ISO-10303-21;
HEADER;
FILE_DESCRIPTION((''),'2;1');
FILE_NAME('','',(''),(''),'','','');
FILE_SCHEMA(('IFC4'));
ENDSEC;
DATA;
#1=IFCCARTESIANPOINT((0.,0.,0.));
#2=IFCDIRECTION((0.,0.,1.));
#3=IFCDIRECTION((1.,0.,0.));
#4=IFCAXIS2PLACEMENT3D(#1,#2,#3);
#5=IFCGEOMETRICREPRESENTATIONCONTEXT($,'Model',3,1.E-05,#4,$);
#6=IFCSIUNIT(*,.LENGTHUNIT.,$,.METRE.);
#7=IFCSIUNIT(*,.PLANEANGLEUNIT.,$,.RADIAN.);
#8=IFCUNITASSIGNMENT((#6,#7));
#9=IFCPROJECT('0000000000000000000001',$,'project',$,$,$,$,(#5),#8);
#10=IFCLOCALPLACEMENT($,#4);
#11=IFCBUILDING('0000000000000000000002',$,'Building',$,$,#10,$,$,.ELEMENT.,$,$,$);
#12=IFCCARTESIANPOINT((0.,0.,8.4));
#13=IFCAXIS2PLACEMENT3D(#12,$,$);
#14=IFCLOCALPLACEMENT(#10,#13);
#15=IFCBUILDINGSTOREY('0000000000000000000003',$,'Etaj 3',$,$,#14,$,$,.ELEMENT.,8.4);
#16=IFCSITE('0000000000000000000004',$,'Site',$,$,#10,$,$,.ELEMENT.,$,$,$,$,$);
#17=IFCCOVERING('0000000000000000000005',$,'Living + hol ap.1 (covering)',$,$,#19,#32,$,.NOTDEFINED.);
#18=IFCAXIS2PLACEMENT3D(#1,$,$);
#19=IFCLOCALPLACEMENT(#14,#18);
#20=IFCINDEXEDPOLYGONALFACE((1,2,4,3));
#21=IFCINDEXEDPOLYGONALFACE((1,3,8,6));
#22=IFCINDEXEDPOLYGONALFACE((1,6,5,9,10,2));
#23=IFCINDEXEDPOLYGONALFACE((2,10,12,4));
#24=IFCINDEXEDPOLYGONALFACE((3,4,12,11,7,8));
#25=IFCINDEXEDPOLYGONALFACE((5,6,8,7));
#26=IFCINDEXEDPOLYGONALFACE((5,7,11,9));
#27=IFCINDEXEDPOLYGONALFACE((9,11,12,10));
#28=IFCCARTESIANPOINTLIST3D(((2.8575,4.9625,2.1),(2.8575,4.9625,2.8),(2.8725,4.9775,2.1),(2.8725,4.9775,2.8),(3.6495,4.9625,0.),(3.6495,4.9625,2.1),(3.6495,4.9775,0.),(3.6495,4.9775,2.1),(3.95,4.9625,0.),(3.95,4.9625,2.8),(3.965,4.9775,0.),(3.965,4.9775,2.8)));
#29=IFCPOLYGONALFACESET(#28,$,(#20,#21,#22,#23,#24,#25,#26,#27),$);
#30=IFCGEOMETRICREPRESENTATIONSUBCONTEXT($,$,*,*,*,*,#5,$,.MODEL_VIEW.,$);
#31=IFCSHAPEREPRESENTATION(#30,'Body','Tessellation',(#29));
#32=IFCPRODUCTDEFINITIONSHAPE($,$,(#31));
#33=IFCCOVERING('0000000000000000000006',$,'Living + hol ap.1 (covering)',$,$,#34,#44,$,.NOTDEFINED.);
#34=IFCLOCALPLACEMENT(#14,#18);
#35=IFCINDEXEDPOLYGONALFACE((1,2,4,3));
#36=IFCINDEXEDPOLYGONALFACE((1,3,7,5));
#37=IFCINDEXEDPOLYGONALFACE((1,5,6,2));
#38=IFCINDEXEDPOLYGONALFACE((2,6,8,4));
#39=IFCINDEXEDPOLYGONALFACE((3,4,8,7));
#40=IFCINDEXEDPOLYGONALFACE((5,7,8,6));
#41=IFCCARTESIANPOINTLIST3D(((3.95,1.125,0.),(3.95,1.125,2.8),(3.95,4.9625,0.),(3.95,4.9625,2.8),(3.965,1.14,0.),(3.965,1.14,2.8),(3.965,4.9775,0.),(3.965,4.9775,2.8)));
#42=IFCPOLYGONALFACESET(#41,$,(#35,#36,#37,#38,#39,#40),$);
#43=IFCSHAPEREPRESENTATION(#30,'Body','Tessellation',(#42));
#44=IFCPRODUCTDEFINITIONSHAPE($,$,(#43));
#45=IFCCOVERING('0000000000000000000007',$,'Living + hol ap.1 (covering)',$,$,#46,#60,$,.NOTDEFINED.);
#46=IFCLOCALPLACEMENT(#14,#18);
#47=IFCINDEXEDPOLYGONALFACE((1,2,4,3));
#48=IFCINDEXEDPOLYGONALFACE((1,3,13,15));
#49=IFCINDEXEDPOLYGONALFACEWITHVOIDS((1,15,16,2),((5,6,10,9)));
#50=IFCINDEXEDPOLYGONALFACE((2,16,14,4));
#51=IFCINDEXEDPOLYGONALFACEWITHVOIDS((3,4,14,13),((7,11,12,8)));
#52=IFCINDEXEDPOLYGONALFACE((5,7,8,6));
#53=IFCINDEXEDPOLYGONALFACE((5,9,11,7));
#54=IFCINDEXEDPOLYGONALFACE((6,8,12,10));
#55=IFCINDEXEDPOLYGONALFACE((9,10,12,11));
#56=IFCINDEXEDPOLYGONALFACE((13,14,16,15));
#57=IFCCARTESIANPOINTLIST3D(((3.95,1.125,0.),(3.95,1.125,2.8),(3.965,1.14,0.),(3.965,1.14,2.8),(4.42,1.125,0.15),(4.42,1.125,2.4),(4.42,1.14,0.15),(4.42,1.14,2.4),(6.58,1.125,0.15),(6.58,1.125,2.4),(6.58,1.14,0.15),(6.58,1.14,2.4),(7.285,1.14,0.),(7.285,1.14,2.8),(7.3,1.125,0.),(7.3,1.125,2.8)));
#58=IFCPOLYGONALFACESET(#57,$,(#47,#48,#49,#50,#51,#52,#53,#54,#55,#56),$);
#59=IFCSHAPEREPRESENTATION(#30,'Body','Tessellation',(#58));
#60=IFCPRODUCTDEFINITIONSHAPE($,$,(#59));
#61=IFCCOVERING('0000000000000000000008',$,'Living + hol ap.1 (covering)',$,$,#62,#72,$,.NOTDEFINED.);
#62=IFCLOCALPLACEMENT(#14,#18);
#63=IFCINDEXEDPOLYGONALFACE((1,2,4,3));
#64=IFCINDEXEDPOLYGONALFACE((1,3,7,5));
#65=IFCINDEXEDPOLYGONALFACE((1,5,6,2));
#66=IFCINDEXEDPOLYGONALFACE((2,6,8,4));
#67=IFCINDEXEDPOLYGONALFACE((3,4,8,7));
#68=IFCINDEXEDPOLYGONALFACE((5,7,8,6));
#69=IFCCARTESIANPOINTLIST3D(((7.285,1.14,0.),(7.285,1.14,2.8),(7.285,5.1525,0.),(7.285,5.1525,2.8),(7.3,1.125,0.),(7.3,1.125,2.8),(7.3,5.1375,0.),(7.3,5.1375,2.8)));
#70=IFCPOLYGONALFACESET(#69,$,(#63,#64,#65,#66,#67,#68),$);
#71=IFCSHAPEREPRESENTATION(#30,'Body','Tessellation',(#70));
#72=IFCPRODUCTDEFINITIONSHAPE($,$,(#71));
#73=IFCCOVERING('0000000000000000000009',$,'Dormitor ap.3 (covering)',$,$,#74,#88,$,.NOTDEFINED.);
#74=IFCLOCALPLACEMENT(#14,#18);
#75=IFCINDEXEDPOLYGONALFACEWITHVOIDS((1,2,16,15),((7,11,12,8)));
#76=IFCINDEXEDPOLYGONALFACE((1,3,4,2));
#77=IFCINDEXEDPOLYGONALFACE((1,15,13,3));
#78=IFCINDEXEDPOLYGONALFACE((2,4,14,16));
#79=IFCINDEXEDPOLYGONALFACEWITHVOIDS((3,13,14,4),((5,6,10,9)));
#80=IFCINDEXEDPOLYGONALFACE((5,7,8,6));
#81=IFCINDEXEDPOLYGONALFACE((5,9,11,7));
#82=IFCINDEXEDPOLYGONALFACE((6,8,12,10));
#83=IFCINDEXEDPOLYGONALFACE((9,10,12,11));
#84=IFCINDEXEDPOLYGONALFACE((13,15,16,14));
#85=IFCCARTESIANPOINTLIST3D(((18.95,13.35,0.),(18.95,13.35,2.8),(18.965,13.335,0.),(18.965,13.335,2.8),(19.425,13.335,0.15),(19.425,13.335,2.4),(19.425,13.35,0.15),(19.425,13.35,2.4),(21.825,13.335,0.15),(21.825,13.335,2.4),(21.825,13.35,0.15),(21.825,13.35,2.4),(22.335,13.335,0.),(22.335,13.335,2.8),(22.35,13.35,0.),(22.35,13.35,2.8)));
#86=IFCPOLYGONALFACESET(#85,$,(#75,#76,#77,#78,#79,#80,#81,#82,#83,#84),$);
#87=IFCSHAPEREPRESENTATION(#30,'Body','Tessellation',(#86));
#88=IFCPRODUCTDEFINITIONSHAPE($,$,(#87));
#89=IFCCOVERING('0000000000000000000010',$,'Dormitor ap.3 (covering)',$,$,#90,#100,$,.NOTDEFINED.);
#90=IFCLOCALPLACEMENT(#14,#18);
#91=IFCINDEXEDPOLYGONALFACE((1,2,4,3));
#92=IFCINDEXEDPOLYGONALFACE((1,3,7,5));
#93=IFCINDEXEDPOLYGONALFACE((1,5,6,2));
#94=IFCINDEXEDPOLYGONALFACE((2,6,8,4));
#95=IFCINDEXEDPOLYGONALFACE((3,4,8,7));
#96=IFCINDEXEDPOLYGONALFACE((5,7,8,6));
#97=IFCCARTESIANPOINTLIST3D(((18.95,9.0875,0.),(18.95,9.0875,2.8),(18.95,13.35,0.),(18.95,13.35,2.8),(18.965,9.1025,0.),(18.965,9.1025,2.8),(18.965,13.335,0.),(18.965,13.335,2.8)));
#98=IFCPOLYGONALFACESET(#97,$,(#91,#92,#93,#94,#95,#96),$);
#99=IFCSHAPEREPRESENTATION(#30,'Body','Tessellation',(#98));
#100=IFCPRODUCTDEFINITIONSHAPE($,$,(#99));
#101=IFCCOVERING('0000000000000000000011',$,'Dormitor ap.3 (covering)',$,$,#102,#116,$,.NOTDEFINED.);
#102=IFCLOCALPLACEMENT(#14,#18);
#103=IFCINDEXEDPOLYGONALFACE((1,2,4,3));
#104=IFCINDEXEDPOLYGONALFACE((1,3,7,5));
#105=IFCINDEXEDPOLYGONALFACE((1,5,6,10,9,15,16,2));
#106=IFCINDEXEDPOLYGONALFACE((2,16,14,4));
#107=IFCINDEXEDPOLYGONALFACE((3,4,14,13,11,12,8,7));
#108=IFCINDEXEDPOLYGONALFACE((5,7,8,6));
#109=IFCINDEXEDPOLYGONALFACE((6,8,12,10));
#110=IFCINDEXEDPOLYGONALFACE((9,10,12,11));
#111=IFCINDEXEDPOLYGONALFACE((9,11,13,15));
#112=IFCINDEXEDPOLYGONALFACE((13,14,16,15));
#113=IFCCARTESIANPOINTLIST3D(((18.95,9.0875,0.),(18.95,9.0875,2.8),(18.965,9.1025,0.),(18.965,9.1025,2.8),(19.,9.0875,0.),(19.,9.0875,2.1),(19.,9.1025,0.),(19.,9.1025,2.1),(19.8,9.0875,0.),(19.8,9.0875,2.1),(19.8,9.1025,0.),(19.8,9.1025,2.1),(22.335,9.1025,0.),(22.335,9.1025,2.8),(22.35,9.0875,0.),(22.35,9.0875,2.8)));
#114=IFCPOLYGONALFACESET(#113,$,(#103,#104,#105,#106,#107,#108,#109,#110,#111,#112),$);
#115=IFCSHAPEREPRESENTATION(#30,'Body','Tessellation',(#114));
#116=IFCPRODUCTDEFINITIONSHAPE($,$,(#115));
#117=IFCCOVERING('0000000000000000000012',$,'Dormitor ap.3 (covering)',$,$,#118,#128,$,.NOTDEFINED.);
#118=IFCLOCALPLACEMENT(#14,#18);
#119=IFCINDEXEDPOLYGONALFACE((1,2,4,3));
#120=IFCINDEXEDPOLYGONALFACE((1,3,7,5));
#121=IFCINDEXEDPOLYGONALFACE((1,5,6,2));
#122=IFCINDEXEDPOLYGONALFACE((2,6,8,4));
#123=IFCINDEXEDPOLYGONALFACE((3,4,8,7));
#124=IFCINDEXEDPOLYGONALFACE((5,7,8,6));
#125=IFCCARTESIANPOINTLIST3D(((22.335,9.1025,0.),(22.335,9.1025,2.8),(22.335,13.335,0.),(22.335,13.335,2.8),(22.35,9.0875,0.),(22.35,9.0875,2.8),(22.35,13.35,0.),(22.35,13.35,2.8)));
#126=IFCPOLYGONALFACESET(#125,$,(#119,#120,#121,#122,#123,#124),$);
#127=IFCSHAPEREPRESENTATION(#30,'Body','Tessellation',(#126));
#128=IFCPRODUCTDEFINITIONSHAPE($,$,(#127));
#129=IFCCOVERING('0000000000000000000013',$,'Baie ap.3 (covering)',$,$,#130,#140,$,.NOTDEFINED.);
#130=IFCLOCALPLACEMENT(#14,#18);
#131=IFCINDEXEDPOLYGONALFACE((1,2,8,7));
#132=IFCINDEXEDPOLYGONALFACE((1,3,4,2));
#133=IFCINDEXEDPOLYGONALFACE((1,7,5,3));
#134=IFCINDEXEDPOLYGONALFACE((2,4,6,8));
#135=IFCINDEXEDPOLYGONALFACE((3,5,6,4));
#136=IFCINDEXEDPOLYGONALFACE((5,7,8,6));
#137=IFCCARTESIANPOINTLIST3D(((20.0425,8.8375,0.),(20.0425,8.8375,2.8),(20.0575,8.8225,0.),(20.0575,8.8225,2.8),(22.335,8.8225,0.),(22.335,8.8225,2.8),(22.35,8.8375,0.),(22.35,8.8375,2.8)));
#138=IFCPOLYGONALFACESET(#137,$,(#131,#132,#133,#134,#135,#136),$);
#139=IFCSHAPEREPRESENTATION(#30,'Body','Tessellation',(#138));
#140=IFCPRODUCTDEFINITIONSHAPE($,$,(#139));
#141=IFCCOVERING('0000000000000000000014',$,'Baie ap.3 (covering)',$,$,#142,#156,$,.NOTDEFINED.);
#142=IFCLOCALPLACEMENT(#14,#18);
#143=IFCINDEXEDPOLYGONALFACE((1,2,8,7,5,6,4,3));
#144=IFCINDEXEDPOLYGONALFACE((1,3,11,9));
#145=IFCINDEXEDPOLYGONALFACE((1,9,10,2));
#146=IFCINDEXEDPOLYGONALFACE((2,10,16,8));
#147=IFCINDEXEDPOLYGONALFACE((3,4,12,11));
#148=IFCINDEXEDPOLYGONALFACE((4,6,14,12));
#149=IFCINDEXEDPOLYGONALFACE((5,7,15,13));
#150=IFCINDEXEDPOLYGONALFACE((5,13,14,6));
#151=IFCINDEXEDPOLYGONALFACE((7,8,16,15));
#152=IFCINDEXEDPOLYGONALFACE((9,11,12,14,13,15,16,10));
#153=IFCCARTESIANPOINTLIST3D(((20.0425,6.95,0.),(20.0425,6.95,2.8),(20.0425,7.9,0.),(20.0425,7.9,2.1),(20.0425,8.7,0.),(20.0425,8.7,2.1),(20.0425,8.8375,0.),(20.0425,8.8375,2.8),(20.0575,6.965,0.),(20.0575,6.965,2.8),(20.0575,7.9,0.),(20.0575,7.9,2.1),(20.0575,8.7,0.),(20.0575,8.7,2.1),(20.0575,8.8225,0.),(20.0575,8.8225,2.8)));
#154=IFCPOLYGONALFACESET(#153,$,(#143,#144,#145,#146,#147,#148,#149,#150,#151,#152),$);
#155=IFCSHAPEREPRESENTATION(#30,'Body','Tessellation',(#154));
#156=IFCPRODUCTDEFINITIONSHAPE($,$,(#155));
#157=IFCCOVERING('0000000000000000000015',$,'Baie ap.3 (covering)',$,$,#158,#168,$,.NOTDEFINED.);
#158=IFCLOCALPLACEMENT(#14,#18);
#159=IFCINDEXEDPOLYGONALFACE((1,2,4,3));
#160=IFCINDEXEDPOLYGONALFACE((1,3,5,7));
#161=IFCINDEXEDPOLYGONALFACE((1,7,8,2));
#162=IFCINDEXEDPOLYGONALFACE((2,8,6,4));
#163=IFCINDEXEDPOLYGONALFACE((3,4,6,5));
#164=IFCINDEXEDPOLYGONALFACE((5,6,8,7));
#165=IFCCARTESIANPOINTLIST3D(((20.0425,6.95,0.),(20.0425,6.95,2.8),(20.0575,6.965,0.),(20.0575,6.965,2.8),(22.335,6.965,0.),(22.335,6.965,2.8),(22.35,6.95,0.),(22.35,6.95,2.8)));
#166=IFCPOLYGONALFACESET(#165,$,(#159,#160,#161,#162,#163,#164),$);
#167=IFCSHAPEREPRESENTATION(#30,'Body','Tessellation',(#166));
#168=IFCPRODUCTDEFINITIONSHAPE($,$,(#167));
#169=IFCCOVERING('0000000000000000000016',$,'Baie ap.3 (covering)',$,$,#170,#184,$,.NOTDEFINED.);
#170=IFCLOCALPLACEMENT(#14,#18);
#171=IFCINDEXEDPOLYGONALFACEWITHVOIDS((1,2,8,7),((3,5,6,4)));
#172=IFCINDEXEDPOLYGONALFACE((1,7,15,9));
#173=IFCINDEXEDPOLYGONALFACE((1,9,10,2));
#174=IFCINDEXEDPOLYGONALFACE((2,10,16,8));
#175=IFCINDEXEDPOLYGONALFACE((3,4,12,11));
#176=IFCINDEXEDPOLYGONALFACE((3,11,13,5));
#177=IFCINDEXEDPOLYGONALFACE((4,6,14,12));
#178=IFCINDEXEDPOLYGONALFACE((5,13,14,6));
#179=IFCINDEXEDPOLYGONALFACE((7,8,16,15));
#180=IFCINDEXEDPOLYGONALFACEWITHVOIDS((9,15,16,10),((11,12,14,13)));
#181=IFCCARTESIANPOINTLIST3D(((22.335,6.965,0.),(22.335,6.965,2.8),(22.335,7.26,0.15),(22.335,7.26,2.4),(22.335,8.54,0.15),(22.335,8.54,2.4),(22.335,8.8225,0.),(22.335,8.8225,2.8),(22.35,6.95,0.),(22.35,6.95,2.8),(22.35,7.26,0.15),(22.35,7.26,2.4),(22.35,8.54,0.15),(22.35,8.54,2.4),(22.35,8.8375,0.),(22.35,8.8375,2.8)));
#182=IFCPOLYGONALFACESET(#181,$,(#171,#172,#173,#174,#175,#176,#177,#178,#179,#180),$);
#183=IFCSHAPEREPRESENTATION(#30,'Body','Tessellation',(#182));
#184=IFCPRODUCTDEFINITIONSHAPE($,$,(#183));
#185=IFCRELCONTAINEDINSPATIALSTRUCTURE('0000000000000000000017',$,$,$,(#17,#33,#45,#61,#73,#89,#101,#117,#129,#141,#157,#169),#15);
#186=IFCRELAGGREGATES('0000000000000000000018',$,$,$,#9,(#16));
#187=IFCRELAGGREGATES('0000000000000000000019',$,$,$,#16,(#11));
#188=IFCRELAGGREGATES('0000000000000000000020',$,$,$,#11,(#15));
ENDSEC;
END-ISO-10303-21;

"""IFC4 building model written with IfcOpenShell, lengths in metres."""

from ifc_helpers import new_model, si_unit, frame, origin, origin_with_axes, origin_2d, place, context, subcontext, project, spatial, polyline, rectangle, outline, extrude, element, save


model = new_model("IFC4")

# Units and contexts
model_context = context("Model", 3, precision=1e-05, world=origin_with_axes())
sub_context = subcontext(model_context, None, None, "MODEL_VIEW")
ifc_project = project(units=[si_unit("LENGTHUNIT", "METRE"), si_unit("PLANEANGLEUNIT", "RADIAN")], contexts=[model_context])

# Site, building, storey
placement = place(None, origin_with_axes())
site = spatial("IfcSite", under=ifc_project, at=placement, Name="Site", CompositionType="ELEMENT")
building = spatial("IfcBuilding", under=site, at=placement, Name="Building", CompositionType="ELEMENT")
storey_placement = place(placement, frame((0.0, 0.0, 8.4)))
storey = spatial("IfcBuildingStorey", under=building, at=storey_placement, Name="Etaj 3", CompositionType="ELEMENT", Elevation=8.4)

# Covering, opening
covering_1_placement = place(storey_placement, origin_with_axes())
covering_1 = element("IfcCovering", 1, at=covering_1_placement, inside=storey, Name="Living + hol ap.1 (covering)", PredefinedType="NOTDEFINED", context=sub_context, shape_type="SweptSolid", body=[
    extrude(outline(polyline([(2.8575, 4.9625), (3.95, 4.9625), (3.965, 4.9775), (2.8725, 4.9775), (2.8575, 4.9625)])), origin(), (0.0, 0.0, 1.0), 2.8),
])
opening_1_placement = place(covering_1_placement, frame((3.2495, 5.0275, 0.0), z_axis=(0.0, -1.0, 0.0), x_axis=(1.0, 0.0, 0.0)))
element("IfcOpeningElement", 2, at=opening_1_placement, cuts=covering_1, PredefinedType="OPENING", context=sub_context, shape_type="SweptSolid", body=[
    extrude(rectangle(XDim=0.8, YDim=2.1, at=origin_2d()), frame((0.0, 1.05, 0.0)), (0.0, 0.0, 1.0), 0.38),
])

# Covering
covering_2_placement = place(storey_placement, origin_with_axes())
element("IfcCovering", 3, at=covering_2_placement, inside=storey, Name="Living + hol ap.1 (covering)", PredefinedType="NOTDEFINED", context=sub_context, shape_type="SweptSolid", body=[
    extrude(outline(polyline([(3.95, 4.9625), (3.95, 1.125), (3.965, 1.14), (3.965, 4.9775), (3.95, 4.9625)])), origin(), (0.0, 0.0, 1.0), 2.8),
])

# Covering, opening
covering_3_placement = place(storey_placement, origin_with_axes())
covering_3 = element("IfcCovering", 4, at=covering_3_placement, inside=storey, Name="Living + hol ap.1 (covering)", PredefinedType="NOTDEFINED", context=sub_context, shape_type="SweptSolid", body=[
    extrude(outline(polyline([(3.95, 1.125), (7.3, 1.125), (7.285, 1.14), (3.965, 1.14), (3.95, 1.125)])), origin(), (0.0, 0.0, 1.0), 2.8),
])
opening_2_placement = place(covering_3_placement, frame((5.5, 1.19, 0.15), z_axis=(0.0, -1.0, 0.0), x_axis=(1.0, 0.0, 0.0)))
element("IfcOpeningElement", 5, at=opening_2_placement, cuts=covering_3, PredefinedType="OPENING", context=sub_context, shape_type="SweptSolid", body=[
    extrude(rectangle(XDim=2.16, YDim=2.25, at=origin_2d()), frame((0.0, 1.125, 0.0)), (0.0, 0.0, 1.0), 0.38),
])

# Covering
covering_4_placement = place(storey_placement, origin_with_axes())
element("IfcCovering", 6, at=covering_4_placement, inside=storey, Name="Living + hol ap.1 (covering)", PredefinedType="NOTDEFINED", context=sub_context, shape_type="SweptSolid", body=[
    extrude(outline(polyline([(7.3, 1.125), (7.3, 5.1375), (7.285, 5.1525), (7.285, 1.14), (7.3, 1.125)])), origin(), (0.0, 0.0, 1.0), 2.8),
])

# Covering, opening
covering_5_placement = place(storey_placement, origin_with_axes())
covering_5 = element("IfcCovering", 7, at=covering_5_placement, inside=storey, Name="Dormitor ap.3 (covering)", PredefinedType="NOTDEFINED", context=sub_context, shape_type="SweptSolid", body=[
    extrude(outline(polyline([(22.35, 13.35), (18.95, 13.35), (18.965, 13.335), (22.335, 13.335), (22.35, 13.35)])), origin(), (0.0, 0.0, 1.0), 2.8),
])
opening_3_placement = place(covering_5_placement, frame((20.625, 13.665, 0.15), z_axis=(0.0, -1.0, 0.0), x_axis=(1.0, 0.0, 0.0)))
element("IfcOpeningElement", 8, at=opening_3_placement, cuts=covering_5, PredefinedType="OPENING", context=sub_context, shape_type="SweptSolid", body=[
    extrude(rectangle(XDim=2.4, YDim=2.25, at=origin_2d()), frame((0.0, 1.125, 0.0)), (0.0, 0.0, 1.0), 0.38),
])

# Covering
covering_6_placement = place(storey_placement, origin_with_axes())
element("IfcCovering", 9, at=covering_6_placement, inside=storey, Name="Dormitor ap.3 (covering)", PredefinedType="NOTDEFINED", context=sub_context, shape_type="SweptSolid", body=[
    extrude(outline(polyline([(18.95, 13.35), (18.95, 9.0875), (18.965, 9.1025), (18.965, 13.335), (18.95, 13.35)])), origin(), (0.0, 0.0, 1.0), 2.8),
])

# Covering, opening
covering_7_placement = place(storey_placement, origin_with_axes())
covering_7 = element("IfcCovering", 10, at=covering_7_placement, inside=storey, Name="Dormitor ap.3 (covering)", PredefinedType="NOTDEFINED", context=sub_context, shape_type="SweptSolid", body=[
    extrude(outline(polyline([(18.95, 9.0875), (22.35, 9.0875), (22.335, 9.1025), (18.965, 9.1025), (18.95, 9.0875)])), origin(), (0.0, 0.0, 1.0), 2.8),
])
opening_4_placement = place(covering_7_placement, frame((19.4, 9.1525, 0.0), z_axis=(0.0, -1.0, 0.0), x_axis=(1.0, 0.0, 0.0)))
element("IfcOpeningElement", 11, at=opening_4_placement, cuts=covering_7, PredefinedType="OPENING", context=sub_context, shape_type="SweptSolid", body=[
    extrude(rectangle(XDim=0.8, YDim=2.1, at=origin_2d()), frame((0.0, 1.05, 0.0)), (0.0, 0.0, 1.0), 0.38),
])

# Coverings
covering_8_placement = place(storey_placement, origin_with_axes())
element("IfcCovering", 12, at=covering_8_placement, inside=storey, Name="Dormitor ap.3 (covering)", PredefinedType="NOTDEFINED", context=sub_context, shape_type="SweptSolid", body=[
    extrude(outline(polyline([(22.35, 9.0875), (22.35, 13.35), (22.335, 13.335), (22.335, 9.1025), (22.35, 9.0875)])), origin(), (0.0, 0.0, 1.0), 2.8),
])
covering_9_placement = place(storey_placement, origin_with_axes())
element("IfcCovering", 13, at=covering_9_placement, inside=storey, Name="Baie ap.3 (covering)", PredefinedType="NOTDEFINED", context=sub_context, shape_type="SweptSolid", body=[
    extrude(outline(polyline([(22.35, 8.8375), (20.0425, 8.8375), (20.0575, 8.8225), (22.335, 8.8225), (22.35, 8.8375)])), origin(), (0.0, 0.0, 1.0), 2.8),
])

# Covering, opening
covering_10_placement = place(storey_placement, origin_with_axes())
covering_10 = element("IfcCovering", 14, at=covering_10_placement, inside=storey, Name="Baie ap.3 (covering)", PredefinedType="NOTDEFINED", context=sub_context, shape_type="SweptSolid", body=[
    extrude(outline(polyline([(20.0425, 8.8375), (20.0425, 6.95), (20.0575, 6.965), (20.0575, 8.8225), (20.0425, 8.8375)])), origin(), (0.0, 0.0, 1.0), 2.8),
])
opening_5_placement = place(covering_10_placement, frame((19.7275, 8.3, 0.0), z_axis=(1.0, 0.0, 0.0), x_axis=(0.0, 1.0, 0.0)))
element("IfcOpeningElement", 15, at=opening_5_placement, cuts=covering_10, PredefinedType="OPENING", context=sub_context, shape_type="SweptSolid", body=[
    extrude(rectangle(XDim=0.8, YDim=2.1, at=origin_2d()), frame((0.0, 1.05, 0.0)), (0.0, 0.0, 1.0), 0.38),
])

# Covering
covering_11_placement = place(storey_placement, origin_with_axes())
element("IfcCovering", 16, at=covering_11_placement, inside=storey, Name="Baie ap.3 (covering)", PredefinedType="NOTDEFINED", context=sub_context, shape_type="SweptSolid", body=[
    extrude(outline(polyline([(20.0425, 6.95), (22.35, 6.95), (22.335, 6.965), (20.0575, 6.965), (20.0425, 6.95)])), origin(), (0.0, 0.0, 1.0), 2.8),
])

# Covering, opening
covering_12_placement = place(storey_placement, origin_with_axes())
covering_12 = element("IfcCovering", 17, at=covering_12_placement, inside=storey, Name="Baie ap.3 (covering)", PredefinedType="NOTDEFINED", context=sub_context, shape_type="SweptSolid", body=[
    extrude(outline(polyline([(22.35, 6.95), (22.35, 8.8375), (22.335, 8.8225), (22.335, 6.965), (22.35, 6.95)])), origin(), (0.0, 0.0, 1.0), 2.8),
])
opening_6_placement = place(covering_12_placement, frame((22.285, 7.9, 0.15), z_axis=(1.0, 0.0, 0.0), x_axis=(0.0, 1.0, 0.0)))
element("IfcOpeningElement", 18, at=opening_6_placement, cuts=covering_12, PredefinedType="OPENING", context=sub_context, shape_type="SweptSolid", body=[
    extrude(rectangle(XDim=1.28, YDim=2.25, at=origin_2d()), frame((0.0, 1.125, 0.0)), (0.0, 0.0, 1.0), 0.38),
])

save(model, "model.ifc")
